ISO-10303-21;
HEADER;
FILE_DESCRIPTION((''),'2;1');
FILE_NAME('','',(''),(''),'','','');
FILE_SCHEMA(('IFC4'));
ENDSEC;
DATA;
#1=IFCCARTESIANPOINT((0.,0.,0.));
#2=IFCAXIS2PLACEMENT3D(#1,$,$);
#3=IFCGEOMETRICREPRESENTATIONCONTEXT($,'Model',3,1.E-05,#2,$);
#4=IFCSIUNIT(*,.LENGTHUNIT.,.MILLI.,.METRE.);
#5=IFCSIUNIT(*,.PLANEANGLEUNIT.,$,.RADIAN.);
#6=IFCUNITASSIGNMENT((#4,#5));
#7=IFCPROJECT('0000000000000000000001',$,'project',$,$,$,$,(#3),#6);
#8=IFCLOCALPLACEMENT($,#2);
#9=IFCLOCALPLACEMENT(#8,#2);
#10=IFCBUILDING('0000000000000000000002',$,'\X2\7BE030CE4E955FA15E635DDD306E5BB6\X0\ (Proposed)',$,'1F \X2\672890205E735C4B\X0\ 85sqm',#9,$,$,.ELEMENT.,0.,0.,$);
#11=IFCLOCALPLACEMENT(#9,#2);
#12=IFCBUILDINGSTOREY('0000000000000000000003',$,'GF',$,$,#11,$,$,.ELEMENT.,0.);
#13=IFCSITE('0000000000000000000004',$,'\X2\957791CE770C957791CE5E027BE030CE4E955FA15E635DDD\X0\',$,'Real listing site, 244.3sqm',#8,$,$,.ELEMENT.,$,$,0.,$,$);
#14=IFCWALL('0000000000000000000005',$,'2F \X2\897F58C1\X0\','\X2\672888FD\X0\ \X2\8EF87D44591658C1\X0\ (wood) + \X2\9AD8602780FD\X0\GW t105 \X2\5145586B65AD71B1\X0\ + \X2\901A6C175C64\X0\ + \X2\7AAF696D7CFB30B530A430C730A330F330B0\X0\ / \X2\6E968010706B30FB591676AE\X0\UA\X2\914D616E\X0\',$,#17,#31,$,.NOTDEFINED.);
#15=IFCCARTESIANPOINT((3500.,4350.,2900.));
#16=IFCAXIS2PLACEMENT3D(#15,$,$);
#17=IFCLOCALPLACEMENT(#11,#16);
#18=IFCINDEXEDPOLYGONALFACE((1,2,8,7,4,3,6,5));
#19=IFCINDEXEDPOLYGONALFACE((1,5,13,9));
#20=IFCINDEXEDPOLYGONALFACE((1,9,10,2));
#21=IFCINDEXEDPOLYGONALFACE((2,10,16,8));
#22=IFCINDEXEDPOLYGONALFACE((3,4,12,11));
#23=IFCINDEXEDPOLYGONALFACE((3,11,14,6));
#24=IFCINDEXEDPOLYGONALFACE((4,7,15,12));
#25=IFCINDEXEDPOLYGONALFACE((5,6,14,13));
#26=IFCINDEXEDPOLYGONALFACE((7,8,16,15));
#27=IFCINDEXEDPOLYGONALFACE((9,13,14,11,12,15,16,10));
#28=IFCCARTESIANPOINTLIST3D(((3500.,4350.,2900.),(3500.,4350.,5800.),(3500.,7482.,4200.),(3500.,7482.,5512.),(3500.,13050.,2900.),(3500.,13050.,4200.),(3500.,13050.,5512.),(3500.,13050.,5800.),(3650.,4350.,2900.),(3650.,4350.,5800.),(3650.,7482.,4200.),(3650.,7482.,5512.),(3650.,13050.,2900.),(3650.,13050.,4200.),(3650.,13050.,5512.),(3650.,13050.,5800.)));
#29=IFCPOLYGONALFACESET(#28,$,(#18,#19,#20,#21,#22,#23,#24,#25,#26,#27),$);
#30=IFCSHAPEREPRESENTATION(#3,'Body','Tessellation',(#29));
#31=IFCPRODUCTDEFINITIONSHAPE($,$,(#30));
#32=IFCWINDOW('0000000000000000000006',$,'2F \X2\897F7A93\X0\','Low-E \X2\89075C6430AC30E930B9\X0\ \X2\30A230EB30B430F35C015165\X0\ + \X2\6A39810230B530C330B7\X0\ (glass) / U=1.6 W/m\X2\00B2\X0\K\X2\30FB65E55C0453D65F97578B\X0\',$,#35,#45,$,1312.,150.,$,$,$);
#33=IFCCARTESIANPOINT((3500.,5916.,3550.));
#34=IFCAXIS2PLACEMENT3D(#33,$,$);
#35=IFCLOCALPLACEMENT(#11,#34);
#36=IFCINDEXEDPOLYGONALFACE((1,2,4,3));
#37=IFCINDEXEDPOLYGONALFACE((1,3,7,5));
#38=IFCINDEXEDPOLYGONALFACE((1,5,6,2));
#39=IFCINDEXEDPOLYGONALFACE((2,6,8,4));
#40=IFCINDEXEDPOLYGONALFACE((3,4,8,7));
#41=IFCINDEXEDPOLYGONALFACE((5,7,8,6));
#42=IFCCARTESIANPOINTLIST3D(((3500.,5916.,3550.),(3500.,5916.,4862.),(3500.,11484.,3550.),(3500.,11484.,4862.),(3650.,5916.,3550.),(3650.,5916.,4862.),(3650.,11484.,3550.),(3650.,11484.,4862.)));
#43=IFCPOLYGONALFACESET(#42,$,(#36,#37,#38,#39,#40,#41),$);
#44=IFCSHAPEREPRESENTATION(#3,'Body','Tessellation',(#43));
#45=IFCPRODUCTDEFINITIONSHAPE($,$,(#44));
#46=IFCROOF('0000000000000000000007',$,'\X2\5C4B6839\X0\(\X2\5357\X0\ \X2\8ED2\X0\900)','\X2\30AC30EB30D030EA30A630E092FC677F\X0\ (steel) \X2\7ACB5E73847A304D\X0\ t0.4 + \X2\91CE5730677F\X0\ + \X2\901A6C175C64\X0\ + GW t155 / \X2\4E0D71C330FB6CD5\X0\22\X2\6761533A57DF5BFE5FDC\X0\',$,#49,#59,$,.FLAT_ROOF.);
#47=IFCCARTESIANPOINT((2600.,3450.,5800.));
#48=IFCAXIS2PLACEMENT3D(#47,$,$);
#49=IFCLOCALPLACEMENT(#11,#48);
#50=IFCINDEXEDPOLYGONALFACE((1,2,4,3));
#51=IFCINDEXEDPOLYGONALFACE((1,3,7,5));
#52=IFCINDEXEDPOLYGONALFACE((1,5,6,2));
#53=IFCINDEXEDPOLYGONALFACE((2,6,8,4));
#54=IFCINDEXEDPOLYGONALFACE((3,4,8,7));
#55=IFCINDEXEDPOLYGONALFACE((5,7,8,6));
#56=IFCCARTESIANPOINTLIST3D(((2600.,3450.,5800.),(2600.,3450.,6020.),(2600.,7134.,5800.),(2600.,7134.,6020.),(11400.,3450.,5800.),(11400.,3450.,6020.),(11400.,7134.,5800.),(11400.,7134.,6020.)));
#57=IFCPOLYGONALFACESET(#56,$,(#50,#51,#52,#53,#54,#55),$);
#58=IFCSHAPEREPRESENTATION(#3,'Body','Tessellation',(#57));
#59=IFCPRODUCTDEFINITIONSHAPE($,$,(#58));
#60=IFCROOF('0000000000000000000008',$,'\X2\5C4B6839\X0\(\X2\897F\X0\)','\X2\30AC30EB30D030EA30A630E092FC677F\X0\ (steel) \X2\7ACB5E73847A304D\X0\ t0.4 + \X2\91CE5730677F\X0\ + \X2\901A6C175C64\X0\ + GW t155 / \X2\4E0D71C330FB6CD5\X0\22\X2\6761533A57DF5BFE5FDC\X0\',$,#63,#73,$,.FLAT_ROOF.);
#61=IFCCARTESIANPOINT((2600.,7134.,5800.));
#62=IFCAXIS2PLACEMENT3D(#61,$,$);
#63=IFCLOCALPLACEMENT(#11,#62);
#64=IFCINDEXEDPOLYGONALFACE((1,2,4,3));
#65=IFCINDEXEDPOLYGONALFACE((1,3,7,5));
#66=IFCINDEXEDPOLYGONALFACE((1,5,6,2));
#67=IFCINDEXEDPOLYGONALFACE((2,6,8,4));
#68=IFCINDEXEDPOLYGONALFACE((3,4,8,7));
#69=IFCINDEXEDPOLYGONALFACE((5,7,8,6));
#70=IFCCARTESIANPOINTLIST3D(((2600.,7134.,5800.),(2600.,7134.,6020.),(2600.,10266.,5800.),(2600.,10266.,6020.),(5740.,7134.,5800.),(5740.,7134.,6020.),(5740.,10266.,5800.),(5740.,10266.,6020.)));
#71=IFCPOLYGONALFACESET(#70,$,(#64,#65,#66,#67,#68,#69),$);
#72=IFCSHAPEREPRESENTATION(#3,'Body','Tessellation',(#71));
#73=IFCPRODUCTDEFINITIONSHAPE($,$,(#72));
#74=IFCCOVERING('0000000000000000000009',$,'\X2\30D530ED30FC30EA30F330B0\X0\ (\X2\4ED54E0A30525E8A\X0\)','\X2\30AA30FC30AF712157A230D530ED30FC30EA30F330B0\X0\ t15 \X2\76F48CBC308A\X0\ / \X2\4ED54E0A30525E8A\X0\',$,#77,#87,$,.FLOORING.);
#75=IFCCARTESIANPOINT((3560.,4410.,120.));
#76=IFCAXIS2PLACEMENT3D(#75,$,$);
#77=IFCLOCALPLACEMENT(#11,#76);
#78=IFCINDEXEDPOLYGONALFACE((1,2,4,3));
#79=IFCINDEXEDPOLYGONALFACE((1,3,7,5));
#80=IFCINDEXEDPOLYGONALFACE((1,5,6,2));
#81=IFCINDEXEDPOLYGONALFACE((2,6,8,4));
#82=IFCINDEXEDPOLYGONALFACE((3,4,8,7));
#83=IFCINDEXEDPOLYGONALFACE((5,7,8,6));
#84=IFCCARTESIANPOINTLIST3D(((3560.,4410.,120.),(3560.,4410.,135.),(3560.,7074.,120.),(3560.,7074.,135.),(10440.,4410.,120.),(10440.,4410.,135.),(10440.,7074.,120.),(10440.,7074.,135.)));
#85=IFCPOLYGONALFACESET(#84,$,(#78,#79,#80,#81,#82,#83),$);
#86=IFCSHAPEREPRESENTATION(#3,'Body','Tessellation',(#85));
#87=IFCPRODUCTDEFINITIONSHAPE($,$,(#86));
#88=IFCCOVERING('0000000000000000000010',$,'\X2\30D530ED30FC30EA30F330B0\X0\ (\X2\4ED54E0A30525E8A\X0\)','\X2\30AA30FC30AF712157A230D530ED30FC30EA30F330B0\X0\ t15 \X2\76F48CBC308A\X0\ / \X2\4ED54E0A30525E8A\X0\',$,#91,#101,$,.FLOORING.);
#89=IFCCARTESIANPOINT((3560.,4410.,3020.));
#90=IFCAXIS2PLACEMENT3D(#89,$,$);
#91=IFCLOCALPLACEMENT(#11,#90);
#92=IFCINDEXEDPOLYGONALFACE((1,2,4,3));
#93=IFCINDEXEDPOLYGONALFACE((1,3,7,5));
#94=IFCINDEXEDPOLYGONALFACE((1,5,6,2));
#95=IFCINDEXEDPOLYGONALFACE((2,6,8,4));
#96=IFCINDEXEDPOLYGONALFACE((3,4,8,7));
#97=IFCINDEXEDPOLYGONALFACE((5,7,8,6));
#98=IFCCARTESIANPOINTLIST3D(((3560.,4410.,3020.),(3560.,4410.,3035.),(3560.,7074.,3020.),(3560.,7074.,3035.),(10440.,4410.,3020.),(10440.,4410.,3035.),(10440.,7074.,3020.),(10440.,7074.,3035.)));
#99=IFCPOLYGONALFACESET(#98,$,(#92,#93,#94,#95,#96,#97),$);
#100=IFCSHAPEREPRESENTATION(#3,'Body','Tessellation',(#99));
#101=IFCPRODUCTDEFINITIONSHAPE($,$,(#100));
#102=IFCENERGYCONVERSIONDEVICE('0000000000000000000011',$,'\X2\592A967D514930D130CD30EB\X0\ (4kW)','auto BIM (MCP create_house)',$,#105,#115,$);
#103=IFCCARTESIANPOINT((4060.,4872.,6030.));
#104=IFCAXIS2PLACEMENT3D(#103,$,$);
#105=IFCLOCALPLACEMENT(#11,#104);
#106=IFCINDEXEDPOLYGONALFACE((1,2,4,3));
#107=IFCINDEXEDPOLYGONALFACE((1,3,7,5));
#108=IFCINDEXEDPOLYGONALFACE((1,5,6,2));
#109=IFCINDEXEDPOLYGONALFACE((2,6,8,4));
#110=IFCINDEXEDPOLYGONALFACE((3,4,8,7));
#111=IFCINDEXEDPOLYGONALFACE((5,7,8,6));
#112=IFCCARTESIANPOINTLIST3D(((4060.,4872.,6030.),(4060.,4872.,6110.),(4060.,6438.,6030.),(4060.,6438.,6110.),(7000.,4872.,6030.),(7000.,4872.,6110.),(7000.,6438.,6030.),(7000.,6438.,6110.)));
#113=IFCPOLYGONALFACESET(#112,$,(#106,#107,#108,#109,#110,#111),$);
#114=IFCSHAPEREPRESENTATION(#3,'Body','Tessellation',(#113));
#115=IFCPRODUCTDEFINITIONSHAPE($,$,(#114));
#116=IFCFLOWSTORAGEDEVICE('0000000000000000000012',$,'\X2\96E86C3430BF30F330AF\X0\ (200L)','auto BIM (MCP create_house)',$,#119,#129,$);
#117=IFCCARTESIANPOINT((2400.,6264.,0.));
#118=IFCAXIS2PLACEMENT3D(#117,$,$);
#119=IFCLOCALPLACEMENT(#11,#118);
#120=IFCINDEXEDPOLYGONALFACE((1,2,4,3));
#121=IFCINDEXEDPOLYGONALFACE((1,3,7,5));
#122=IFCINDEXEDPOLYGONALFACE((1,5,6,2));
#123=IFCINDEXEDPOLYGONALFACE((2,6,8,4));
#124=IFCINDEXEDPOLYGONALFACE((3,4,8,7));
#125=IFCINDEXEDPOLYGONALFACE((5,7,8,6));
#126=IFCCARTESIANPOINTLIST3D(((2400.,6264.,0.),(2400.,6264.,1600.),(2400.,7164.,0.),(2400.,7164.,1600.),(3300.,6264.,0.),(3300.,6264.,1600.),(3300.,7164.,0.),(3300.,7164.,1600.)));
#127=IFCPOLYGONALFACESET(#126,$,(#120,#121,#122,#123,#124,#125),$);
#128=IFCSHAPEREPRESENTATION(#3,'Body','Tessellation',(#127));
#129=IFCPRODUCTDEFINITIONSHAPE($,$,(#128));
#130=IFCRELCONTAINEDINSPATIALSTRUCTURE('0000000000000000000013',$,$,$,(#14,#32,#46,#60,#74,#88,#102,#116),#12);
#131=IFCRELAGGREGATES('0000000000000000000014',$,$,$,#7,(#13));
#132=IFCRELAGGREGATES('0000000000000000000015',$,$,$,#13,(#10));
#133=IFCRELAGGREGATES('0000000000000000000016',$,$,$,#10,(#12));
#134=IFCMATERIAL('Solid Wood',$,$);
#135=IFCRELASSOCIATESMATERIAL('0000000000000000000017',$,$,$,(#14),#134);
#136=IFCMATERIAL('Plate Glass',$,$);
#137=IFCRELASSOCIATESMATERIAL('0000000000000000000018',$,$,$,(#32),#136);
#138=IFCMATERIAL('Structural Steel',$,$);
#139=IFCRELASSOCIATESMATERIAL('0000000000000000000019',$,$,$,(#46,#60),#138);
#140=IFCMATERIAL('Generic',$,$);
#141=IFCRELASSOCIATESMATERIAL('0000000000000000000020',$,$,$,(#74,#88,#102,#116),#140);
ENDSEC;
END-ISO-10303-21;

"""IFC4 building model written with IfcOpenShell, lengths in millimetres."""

from ifc_helpers import new_model, si_unit, frame, frame_2d, origin, place, context, project, spatial, rectangle, extrude, material, element, fill, save


model = new_model("IFC4")

# Units and contexts
model_context = context("Model", 3, precision=1e-05, world=origin())
ifc_project = project(units=[si_unit("LENGTHUNIT", "METRE", prefix="MILLI"), si_unit("PLANEANGLEUNIT", "RADIAN")], contexts=[model_context])

# Site, building, storey
site_placement = place(None, origin())
site = spatial("IfcSite", under=ifc_project, at=site_placement, Name="長野県長野市篠ノ井御幣川", ObjectType="Real listing site, 244.3sqm", CompositionType="ELEMENT", RefElevation=0.0)
building_placement = place(site_placement, origin())
building = spatial("IfcBuilding", under=site, at=building_placement, Name="篠ノ井御幣川の家 (Proposed)", ObjectType="1F 木造平屋 85sqm", CompositionType="ELEMENT", ElevationOfRefHeight=0.0, ElevationOfTerrain=0.0)
storey_placement = place(building_placement, origin())
storey = spatial("IfcBuildingStorey", under=building, at=storey_placement, Name="GF", CompositionType="ELEMENT", Elevation=0.0)

# Shared definitions
ifc_material_1 = material(Name="Solid Wood")
ifc_material_2 = material(Name="Generic")

# Shared definitions
ifc_material_3 = material(Name="Plate Glass")

# Wall, opening, window
wall_1_placement = place(storey_placement, frame((3500.0, 4350.0, 2900.0)))
wall_1 = element("IfcWall", 1, at=wall_1_placement, inside=storey, material=ifc_material_1, Name="2F 西壁", Description="木製 軸組外壁 (wood) + 高性能GW t105 充填断熱 + 通気層 + 窯業系サイディング / 準耐火・外皮UA配慮", PredefinedType="NOTDEFINED", context=model_context, shape_type="SweptSolid", body=[
    extrude(rectangle(XDim=150.0, YDim=8700.0, at=frame_2d((75.0, 4350.0))), frame((3500.0, 4350.0, 2900.0)), (0.0, 0.0, 1.0), 2900.0),
])
opening_1_placement = place(storey_placement, frame((3500.0, 5916.0, 3550.0)))
opening_1 = element("IfcOpeningElement", 2, at=opening_1_placement, cuts=wall_1, PredefinedType="NOTDEFINED", context=model_context, shape_type="SweptSolid", body=[
    extrude(rectangle(XDim=150.0, YDim=5568.0, at=frame_2d((75.0, 2784.0))), frame((3500.0, 5916.0, 3550.0)), (0.0, 0.0, 1.0), 1312.0),
])
window_1_placement = place(storey_placement, frame((3500.0, 5916.0, 3550.0)))
window_1 = element("IfcWindow", 3, at=window_1_placement, inside=storey, material=ifc_material_3, Name="2F 西窓", Description="Low-E 複層ガラス アルゴン封入 + 樹脂サッシ (glass) / U=1.6 W/m²K・日射取得型", OverallHeight=1312.0, OverallWidth=150.0, context=model_context, shape_type="SweptSolid", body=[
    extrude(rectangle(XDim=150.0, YDim=5568.0, at=frame_2d((75.0, 2784.0))), frame((3500.0, 5916.0, 3550.0)), (0.0, 0.0, 1.0), 1312.0),
])
fill(opening_1, window_1)

# Roofs
ifc_material_4 = material(Name="Structural Steel")
roof_1_placement = place(storey_placement, frame((2600.0, 3450.0, 5800.0)))
element("IfcRoof", 4, at=roof_1_placement, inside=storey, material=ifc_material_4, Name="屋根(南 軒900)", Description="ガルバリウム鋼板 (steel) 立平葺き t0.4 + 野地板 + 通気層 + GW t155 / 不燃・法22条区域対応", PredefinedType="FLAT_ROOF", context=model_context, shape_type="SweptSolid", body=[
    extrude(rectangle(XDim=8800.0, YDim=3684.0, at=frame_2d((4400.0, 1842.0))), frame((2600.0, 3450.0, 5800.0)), (0.0, 0.0, 1.0), 220.0),
])
roof_2_placement = place(storey_placement, frame((2600.0, 7134.0, 5800.0)))
element("IfcRoof", 5, at=roof_2_placement, inside=storey, material=ifc_material_4, Name="屋根(西)", Description="ガルバリウム鋼板 (steel) 立平葺き t0.4 + 野地板 + 通気層 + GW t155 / 不燃・法22条区域対応", PredefinedType="FLAT_ROOF", context=model_context, shape_type="SweptSolid", body=[
    extrude(rectangle(XDim=3140.0, YDim=3132.0, at=frame_2d((1570.0, 1566.0))), frame((2600.0, 7134.0, 5800.0)), (0.0, 0.0, 1.0), 220.0),
])

# Coverings
covering_1_placement = place(storey_placement, frame((3560.0, 4410.0, 120.0)))
element("IfcCovering", 6, at=covering_1_placement, inside=storey, material=ifc_material_2, Name="フローリング (仕上げ床)", Description="オーク無垢フローリング t15 直貼り / 仕上げ床", PredefinedType="FLOORING", context=model_context, shape_type="SweptSolid", body=[
    extrude(rectangle(XDim=6880.0, YDim=2664.0, at=frame_2d((3440.0, 1332.0))), frame((3560.0, 4410.0, 120.0)), (0.0, 0.0, 1.0), 15.0),
])
covering_2_placement = place(storey_placement, frame((3560.0, 4410.0, 3020.0)))
element("IfcCovering", 7, at=covering_2_placement, inside=storey, material=ifc_material_2, Name="フローリング (仕上げ床)", Description="オーク無垢フローリング t15 直貼り / 仕上げ床", PredefinedType="FLOORING", context=model_context, shape_type="SweptSolid", body=[
    extrude(rectangle(XDim=6880.0, YDim=2664.0, at=frame_2d((3440.0, 1332.0))), frame((3560.0, 4410.0, 3020.0)), (0.0, 0.0, 1.0), 15.0),
])

# Energy conversion device
energy_conversion_device_placement = place(storey_placement, frame((4060.0, 4872.0, 6030.0)))
element("IfcEnergyConversionDevice", 8, at=energy_conversion_device_placement, inside=storey, material=ifc_material_2, Name="太陽光パネル (4kW)", Description="auto BIM (MCP create_house)", context=model_context, shape_type="SweptSolid", body=[
    extrude(rectangle(XDim=2940.0, YDim=1566.0, at=frame_2d((1470.0, 783.0))), frame((4060.0, 4872.0, 6030.0)), (0.0, 0.0, 1.0), 80.0),
])

# Flow storage device
flow_storage_device_placement = place(storey_placement, frame((2400.0, 6264.0, 0.0)))
element("IfcFlowStorageDevice", 9, at=flow_storage_device_placement, inside=storey, material=ifc_material_2, Name="雨水タンク (200L)", Description="auto BIM (MCP create_house)", context=model_context, shape_type="SweptSolid", body=[
    extrude(rectangle(XDim=900.0, YDim=900.0, at=frame_2d((450.0, 450.0))), frame((2400.0, 6264.0, 0.0)), (0.0, 0.0, 1.0), 1600.0),
])

save(model, "model.ifc")
